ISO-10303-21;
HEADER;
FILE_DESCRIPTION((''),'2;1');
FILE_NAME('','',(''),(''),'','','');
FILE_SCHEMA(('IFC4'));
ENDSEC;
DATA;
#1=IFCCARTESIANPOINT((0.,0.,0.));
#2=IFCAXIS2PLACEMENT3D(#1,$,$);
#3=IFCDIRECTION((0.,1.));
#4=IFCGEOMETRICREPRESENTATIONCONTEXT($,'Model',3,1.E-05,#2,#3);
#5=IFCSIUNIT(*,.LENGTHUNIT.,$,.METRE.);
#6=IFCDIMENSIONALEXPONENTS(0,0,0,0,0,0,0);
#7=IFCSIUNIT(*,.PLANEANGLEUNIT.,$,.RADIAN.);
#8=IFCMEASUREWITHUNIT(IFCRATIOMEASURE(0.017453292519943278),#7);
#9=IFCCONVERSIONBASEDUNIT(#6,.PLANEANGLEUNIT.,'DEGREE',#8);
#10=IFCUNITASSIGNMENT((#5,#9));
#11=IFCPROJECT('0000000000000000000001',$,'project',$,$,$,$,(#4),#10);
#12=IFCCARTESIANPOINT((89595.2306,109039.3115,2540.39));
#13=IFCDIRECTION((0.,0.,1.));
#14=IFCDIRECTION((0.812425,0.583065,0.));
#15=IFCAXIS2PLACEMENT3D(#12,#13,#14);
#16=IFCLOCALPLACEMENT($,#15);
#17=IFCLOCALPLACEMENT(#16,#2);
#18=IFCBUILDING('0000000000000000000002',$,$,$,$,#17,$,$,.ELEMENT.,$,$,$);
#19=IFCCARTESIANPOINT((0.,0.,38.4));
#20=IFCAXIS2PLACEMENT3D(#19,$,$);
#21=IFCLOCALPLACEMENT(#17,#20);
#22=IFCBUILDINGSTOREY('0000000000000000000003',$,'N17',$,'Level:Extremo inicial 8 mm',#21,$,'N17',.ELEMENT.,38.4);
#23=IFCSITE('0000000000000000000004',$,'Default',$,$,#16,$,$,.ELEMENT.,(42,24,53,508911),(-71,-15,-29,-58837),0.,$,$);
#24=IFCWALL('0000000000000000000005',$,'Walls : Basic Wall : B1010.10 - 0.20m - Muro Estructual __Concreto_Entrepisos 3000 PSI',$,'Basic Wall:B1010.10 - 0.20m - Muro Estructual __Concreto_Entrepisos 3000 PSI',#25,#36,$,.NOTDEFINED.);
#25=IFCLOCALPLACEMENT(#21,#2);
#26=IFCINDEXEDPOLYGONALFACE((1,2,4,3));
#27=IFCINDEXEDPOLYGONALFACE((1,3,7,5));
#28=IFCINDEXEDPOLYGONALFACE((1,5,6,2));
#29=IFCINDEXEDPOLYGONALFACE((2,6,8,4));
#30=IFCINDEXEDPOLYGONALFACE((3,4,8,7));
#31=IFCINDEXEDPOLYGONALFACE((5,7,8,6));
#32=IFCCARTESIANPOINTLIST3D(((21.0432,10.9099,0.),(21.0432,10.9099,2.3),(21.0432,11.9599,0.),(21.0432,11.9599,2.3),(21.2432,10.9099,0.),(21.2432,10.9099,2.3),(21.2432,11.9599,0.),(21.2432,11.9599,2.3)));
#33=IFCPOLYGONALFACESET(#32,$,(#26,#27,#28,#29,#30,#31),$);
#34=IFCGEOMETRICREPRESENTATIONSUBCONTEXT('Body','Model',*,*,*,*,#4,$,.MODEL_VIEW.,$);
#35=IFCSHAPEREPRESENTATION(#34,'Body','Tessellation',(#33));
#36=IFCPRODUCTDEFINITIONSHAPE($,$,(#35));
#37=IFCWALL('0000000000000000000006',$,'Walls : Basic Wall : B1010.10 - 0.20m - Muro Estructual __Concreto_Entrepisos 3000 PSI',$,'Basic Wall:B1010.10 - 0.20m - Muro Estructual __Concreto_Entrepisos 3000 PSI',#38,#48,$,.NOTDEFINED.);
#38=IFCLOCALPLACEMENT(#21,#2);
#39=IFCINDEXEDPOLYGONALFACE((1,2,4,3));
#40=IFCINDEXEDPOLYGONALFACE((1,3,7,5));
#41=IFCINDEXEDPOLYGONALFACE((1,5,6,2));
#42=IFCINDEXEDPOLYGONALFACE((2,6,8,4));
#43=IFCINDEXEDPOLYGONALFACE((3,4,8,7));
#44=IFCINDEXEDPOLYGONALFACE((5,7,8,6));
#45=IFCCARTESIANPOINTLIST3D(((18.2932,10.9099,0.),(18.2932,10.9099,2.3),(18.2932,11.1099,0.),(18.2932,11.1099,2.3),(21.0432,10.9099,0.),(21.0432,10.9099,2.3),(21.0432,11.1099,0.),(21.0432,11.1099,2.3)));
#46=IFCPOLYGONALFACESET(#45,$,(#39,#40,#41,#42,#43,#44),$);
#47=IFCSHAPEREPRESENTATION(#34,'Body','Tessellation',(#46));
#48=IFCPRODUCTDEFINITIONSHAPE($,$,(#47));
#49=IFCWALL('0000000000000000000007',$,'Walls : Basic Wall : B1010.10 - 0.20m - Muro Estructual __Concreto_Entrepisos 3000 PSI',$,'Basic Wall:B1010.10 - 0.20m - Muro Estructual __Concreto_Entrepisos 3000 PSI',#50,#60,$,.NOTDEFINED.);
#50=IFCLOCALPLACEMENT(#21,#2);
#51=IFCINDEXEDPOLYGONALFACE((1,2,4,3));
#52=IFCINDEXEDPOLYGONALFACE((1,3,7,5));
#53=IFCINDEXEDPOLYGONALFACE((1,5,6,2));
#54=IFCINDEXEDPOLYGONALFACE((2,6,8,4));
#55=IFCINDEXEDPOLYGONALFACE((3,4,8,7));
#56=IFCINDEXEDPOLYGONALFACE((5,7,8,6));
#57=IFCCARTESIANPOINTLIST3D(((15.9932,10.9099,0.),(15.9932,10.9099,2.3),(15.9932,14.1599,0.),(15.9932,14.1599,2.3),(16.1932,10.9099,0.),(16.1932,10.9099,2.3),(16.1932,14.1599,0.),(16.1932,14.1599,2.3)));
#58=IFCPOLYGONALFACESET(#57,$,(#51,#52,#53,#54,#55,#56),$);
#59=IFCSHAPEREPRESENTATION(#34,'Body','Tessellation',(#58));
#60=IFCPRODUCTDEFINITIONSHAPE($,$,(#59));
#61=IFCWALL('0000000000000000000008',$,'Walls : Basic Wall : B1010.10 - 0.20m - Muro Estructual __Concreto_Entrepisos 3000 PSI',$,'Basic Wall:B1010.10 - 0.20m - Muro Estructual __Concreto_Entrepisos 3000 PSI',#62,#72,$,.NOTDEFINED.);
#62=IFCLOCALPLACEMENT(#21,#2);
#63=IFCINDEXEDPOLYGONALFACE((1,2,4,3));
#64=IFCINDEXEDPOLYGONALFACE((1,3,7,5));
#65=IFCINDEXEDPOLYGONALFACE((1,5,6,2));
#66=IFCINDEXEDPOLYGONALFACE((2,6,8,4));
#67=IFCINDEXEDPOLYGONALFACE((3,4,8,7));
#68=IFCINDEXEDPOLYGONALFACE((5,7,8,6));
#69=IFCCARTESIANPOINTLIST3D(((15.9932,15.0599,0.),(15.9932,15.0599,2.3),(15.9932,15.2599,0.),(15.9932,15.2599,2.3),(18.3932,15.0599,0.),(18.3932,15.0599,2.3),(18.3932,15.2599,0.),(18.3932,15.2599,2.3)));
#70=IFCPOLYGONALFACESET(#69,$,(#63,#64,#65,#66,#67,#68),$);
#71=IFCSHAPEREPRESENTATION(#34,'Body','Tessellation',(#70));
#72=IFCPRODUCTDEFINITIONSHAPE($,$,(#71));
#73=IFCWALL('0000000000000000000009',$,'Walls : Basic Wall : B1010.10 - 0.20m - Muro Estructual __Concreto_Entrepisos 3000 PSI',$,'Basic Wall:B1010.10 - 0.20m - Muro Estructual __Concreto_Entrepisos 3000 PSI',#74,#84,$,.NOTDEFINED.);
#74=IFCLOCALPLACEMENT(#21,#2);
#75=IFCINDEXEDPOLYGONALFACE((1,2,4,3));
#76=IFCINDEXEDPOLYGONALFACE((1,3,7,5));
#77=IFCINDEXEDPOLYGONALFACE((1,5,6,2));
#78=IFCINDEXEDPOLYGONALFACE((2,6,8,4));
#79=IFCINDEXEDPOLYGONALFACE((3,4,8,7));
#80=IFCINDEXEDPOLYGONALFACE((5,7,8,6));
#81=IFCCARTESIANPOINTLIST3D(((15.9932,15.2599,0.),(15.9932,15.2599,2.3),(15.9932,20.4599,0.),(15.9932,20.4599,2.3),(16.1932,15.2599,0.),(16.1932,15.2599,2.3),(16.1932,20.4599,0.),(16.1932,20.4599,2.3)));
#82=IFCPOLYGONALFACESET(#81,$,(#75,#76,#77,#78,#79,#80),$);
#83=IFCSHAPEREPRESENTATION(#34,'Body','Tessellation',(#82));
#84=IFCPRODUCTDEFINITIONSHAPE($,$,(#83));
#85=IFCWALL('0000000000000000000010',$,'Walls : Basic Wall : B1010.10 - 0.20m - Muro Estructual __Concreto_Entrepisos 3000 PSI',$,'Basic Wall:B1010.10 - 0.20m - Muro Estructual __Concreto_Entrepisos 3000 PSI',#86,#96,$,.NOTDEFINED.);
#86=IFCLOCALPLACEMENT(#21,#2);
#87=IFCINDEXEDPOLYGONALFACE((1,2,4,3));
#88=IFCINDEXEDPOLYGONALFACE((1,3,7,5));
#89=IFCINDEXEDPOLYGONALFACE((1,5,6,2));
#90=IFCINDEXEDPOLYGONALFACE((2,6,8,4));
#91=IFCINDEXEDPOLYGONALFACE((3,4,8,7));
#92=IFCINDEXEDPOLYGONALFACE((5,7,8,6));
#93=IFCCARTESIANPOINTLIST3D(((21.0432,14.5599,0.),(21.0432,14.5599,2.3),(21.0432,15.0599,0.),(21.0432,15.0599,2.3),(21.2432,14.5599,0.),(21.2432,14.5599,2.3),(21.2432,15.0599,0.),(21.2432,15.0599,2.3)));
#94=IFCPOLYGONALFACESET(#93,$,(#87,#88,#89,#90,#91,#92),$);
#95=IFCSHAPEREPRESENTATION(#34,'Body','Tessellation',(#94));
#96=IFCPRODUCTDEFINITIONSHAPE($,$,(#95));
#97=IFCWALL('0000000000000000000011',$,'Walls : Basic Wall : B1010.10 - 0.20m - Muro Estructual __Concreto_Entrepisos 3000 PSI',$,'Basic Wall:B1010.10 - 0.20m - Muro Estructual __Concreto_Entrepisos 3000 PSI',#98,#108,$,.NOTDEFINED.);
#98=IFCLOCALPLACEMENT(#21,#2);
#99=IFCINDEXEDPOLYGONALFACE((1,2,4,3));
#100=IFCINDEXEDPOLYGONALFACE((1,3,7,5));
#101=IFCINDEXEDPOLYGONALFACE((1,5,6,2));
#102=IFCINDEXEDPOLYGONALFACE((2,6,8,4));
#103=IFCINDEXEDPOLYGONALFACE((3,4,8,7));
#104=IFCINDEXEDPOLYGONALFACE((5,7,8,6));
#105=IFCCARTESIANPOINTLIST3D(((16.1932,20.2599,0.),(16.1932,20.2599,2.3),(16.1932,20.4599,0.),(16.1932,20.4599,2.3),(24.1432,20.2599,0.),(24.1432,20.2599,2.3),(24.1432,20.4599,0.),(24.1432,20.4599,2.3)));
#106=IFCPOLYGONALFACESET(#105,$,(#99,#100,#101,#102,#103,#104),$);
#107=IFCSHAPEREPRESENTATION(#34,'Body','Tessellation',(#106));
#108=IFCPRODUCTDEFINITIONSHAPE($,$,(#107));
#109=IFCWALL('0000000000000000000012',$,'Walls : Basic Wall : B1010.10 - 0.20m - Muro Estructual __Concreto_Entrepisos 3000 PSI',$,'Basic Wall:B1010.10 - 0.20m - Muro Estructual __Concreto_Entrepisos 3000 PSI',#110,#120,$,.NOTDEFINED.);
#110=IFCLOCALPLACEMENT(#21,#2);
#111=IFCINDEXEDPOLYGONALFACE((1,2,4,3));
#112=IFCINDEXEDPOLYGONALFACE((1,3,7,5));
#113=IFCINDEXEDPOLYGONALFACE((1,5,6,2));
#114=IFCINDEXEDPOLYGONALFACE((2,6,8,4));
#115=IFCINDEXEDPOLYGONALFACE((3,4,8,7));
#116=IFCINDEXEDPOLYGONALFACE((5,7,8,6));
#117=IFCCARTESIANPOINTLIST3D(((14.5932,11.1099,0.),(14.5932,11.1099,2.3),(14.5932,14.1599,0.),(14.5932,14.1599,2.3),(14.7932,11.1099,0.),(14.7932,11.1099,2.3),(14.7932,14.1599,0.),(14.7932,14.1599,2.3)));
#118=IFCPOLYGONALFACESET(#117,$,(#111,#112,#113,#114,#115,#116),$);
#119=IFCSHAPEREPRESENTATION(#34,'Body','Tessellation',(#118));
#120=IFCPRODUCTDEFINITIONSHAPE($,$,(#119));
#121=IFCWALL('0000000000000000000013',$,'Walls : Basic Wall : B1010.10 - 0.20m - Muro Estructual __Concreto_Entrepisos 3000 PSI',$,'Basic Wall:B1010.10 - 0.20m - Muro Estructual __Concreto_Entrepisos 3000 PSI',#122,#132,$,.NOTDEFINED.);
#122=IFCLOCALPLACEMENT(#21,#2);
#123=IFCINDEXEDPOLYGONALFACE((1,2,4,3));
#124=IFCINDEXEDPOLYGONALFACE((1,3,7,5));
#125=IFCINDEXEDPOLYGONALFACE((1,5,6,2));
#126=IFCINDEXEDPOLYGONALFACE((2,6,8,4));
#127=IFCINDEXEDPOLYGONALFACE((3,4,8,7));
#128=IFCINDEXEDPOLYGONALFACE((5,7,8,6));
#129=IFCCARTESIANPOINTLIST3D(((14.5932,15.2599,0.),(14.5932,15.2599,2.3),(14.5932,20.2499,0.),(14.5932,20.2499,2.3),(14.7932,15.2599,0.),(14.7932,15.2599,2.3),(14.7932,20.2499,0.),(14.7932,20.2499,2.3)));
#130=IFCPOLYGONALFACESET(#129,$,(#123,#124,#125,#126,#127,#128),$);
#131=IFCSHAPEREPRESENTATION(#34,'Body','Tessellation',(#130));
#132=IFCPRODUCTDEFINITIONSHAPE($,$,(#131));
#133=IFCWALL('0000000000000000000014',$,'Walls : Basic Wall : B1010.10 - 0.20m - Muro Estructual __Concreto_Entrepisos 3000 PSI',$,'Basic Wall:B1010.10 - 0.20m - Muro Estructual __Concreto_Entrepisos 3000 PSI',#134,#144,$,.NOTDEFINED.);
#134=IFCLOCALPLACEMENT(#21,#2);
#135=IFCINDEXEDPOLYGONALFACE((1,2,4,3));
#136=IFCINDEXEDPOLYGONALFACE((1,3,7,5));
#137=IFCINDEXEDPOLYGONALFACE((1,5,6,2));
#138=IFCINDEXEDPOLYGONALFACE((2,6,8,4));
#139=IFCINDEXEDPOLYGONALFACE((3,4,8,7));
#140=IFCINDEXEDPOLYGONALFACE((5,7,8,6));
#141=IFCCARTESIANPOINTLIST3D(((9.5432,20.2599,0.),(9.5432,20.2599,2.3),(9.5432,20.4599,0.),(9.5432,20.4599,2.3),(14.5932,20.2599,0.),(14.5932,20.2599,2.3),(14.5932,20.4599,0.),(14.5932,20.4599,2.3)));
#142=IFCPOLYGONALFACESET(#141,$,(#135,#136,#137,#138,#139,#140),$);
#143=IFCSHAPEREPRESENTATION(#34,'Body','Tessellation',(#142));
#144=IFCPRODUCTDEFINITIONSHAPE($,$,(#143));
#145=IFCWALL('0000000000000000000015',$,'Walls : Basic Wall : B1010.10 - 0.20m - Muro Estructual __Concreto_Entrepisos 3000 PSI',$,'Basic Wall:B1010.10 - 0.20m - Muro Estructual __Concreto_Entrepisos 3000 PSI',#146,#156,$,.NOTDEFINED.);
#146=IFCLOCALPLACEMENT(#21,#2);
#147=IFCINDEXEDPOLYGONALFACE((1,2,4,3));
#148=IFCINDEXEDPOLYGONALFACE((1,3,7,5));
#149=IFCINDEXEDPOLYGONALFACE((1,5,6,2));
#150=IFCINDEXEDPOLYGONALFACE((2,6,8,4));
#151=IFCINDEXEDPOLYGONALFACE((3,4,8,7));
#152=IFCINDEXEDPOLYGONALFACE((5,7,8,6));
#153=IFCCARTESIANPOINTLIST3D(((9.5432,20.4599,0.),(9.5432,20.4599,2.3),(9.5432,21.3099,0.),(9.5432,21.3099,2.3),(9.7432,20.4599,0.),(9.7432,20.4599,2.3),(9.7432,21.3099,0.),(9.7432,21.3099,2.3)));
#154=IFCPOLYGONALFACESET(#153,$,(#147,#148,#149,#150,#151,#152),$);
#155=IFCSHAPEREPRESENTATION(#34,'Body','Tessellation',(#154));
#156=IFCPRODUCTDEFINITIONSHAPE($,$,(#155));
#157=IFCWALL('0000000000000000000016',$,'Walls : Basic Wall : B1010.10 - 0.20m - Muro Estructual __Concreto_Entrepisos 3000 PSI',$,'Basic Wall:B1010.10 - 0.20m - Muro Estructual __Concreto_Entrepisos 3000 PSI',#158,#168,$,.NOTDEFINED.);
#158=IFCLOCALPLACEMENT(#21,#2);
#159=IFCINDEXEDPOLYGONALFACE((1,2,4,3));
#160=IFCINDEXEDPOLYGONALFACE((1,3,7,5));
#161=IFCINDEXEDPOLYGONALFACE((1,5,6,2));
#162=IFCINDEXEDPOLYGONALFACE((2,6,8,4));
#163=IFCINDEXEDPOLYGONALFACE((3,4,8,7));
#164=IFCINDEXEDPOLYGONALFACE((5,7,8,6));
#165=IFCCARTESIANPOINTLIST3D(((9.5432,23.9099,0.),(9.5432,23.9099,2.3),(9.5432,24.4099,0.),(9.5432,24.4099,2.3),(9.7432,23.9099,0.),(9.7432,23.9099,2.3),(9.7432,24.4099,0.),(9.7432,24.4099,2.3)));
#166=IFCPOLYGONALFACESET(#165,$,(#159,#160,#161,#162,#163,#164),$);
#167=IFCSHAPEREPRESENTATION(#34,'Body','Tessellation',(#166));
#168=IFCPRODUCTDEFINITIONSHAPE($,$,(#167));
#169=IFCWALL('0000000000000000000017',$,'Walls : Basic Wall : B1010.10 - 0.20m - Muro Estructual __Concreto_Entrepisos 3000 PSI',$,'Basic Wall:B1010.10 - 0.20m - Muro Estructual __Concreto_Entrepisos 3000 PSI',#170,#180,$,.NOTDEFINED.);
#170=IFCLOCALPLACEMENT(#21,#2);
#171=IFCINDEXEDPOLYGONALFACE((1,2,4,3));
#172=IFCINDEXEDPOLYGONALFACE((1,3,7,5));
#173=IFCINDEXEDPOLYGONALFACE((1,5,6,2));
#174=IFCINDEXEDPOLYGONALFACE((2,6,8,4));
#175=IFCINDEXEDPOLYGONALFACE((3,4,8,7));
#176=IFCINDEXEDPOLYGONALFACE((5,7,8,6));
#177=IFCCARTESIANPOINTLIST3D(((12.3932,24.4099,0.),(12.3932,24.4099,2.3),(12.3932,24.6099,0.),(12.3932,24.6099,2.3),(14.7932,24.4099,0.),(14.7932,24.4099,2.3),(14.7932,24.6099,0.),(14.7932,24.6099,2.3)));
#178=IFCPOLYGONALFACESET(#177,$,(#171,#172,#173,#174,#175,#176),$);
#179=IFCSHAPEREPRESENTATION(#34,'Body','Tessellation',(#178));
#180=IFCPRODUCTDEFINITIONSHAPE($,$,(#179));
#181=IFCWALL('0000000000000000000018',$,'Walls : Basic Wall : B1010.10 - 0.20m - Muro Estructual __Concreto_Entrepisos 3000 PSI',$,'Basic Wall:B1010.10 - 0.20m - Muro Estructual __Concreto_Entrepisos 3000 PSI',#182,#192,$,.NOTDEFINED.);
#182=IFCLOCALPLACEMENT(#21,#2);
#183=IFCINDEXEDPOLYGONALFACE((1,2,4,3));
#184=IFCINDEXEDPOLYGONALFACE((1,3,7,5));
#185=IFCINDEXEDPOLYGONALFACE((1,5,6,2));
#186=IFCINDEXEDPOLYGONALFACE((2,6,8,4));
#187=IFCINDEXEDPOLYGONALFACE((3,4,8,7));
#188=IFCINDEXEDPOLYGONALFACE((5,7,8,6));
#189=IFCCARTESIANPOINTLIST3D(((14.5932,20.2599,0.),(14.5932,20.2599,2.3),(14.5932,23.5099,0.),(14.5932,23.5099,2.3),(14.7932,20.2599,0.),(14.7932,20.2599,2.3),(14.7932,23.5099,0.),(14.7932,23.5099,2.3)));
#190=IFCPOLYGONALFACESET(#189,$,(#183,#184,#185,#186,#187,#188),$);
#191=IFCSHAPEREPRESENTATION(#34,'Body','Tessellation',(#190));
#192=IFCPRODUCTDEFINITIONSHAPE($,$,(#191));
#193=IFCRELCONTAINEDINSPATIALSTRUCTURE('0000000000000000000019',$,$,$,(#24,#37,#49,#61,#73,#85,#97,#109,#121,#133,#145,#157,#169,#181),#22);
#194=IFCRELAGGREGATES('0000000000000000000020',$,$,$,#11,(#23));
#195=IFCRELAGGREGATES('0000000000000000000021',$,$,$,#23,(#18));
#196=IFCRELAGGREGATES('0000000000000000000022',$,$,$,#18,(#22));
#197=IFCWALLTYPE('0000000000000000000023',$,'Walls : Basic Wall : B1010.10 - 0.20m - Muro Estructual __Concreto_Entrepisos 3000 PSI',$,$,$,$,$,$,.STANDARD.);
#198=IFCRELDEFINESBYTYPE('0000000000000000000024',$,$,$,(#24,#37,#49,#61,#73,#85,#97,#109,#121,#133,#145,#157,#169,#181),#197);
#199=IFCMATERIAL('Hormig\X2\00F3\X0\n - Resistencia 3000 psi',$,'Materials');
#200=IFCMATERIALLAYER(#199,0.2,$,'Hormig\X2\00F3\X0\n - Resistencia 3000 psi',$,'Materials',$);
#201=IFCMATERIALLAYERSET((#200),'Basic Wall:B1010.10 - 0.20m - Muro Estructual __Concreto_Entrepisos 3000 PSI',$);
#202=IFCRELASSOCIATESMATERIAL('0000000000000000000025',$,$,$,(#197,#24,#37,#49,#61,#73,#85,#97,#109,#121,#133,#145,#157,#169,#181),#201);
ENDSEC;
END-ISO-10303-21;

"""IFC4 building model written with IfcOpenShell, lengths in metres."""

from ifc_helpers import new_model, entity, si_unit, converted_unit, direction, frame, frame_2d, origin, place, context, subcontext, project, spatial, rectangle, extrude, material, layer, layer_set, layer_usage, type_object, element, save


model = new_model("IFC4")

# Units and contexts
model_context = context("Model", 3, precision=1e-05, world=origin(), true_north=direction((0.0, 1.0)))
body_context = subcontext(model_context, "Body", "Model", "MODEL_VIEW")
ifc_project = project(units=[si_unit("LENGTHUNIT", "METRE"), converted_unit("PLANEANGLEUNIT", "DEGREE", entity("IfcRatioMeasure", 0.017453292519943278), si_unit("PLANEANGLEUNIT", "RADIAN"), dimensions=[0, 0, 0, 0, 0, 0, 0])], contexts=[model_context])

# Site, building, storey
site_placement = place(None, frame((89595.2306, 109039.3115, 2540.39), z_axis=(0.0, 0.0, 1.0), x_axis=(0.812425, 0.583065, 0.0)))
site = spatial("IfcSite", under=ifc_project, at=site_placement, Name="Default", CompositionType="ELEMENT", RefLatitude=(42, 24, 53, 508911), RefLongitude=(-71, -15, -29, -58837), RefElevation=0.0)
building_placement = place(site_placement, origin())
building = spatial("IfcBuilding", under=site, at=building_placement, CompositionType="ELEMENT")
storey_placement = place(building_placement, frame((0.0, 0.0, 38.4)))
storey = spatial("IfcBuildingStorey", under=building, at=storey_placement, Name="N17", ObjectType="Level:Extremo inicial 8 mm", LongName="N17", CompositionType="ELEMENT", Elevation=38.4)

# Walls
ifc_material = material(Name="Hormigón - Resistencia 3000 psi", Category="Materials")
ifc_layer_1 = layer(ifc_material, 0.2, Name="Hormigón - Resistencia 3000 psi", Category="Materials")
ifc_layer_set_1 = layer_set([ifc_layer_1], Name="Basic Wall:B1010.10 - 0.20m - Muro Estructual __Concreto_Entrepisos 3000 PSI")
ifc_layer_usage_1 = layer_usage(ifc_layer_set_1, "AXIS2", "NEGATIVE", 0.1)
wall_type_1 = type_object("IfcWallType", Name="Walls : Basic Wall : B1010.10 - 0.20m - Muro Estructual __Concreto_Entrepisos 3000 PSI", PredefinedType="STANDARD", material=ifc_layer_set_1)
wall_1_placement = place(storey_placement, frame((21.1432, 11.9599, 0.0), z_axis=(0.0, 0.0, 1.0), x_axis=(0.0, -1.0, 0.0)))
element("IfcWall", 1, at=wall_1_placement, inside=storey, type_object=wall_type_1, material=ifc_layer_usage_1, Name="Walls : Basic Wall : B1010.10 - 0.20m - Muro Estructual __Concreto_Entrepisos 3000 PSI", ObjectType="Basic Wall:B1010.10 - 0.20m - Muro Estructual __Concreto_Entrepisos 3000 PSI", PredefinedType="NOTDEFINED", context=body_context, shape_type="SweptSolid", body=[
    extrude(rectangle(XDim=1.05, YDim=0.2, at=frame_2d((0.525, 0.0), x_axis=(-1.0, 0.0))), origin(), (0.0, 0.0, 1.0), 2.3),
])
ifc_layer_usage_2 = layer_usage(ifc_layer_set_1, "AXIS2", "NEGATIVE", 0.1)
wall_2_placement = place(storey_placement, frame((21.0432, 11.0099, 0.0), z_axis=(0.0, 0.0, 1.0), x_axis=(-1.0, 0.0, 0.0)))
element("IfcWall", 2, at=wall_2_placement, inside=storey, type_object=wall_type_1, material=ifc_layer_usage_2, Name="Walls : Basic Wall : B1010.10 - 0.20m - Muro Estructual __Concreto_Entrepisos 3000 PSI", ObjectType="Basic Wall:B1010.10 - 0.20m - Muro Estructual __Concreto_Entrepisos 3000 PSI", PredefinedType="NOTDEFINED", context=body_context, shape_type="SweptSolid", body=[
    extrude(rectangle(XDim=2.75, YDim=0.2, at=frame_2d((1.375, 0.0), x_axis=(-1.0, 0.0))), origin(), (0.0, 0.0, 1.0), 2.3),
])
ifc_layer_usage_3 = layer_usage(ifc_layer_set_1, "AXIS2", "NEGATIVE", 0.1)
wall_3_placement = place(storey_placement, frame((16.0932, 14.1599, 0.0), z_axis=(0.0, 0.0, 1.0), x_axis=(0.0, -1.0, 0.0)))
element("IfcWall", 3, at=wall_3_placement, inside=storey, type_object=wall_type_1, material=ifc_layer_usage_3, Name="Walls : Basic Wall : B1010.10 - 0.20m - Muro Estructual __Concreto_Entrepisos 3000 PSI", ObjectType="Basic Wall:B1010.10 - 0.20m - Muro Estructual __Concreto_Entrepisos 3000 PSI", PredefinedType="NOTDEFINED", context=body_context, shape_type="SweptSolid", body=[
    extrude(rectangle(XDim=3.25, YDim=0.2, at=frame_2d((1.625, 0.0), x_axis=(-1.0, 0.0))), origin(), (0.0, 0.0, 1.0), 2.3),
])
ifc_layer_usage_4 = layer_usage(ifc_layer_set_1, "AXIS2", "NEGATIVE", 0.1)
wall_4_placement = place(storey_placement, frame((18.3932, 15.1599, 0.0), z_axis=(0.0, 0.0, 1.0), x_axis=(-1.0, 0.0, 0.0)))
element("IfcWall", 4, at=wall_4_placement, inside=storey, type_object=wall_type_1, material=ifc_layer_usage_4, Name="Walls : Basic Wall : B1010.10 - 0.20m - Muro Estructual __Concreto_Entrepisos 3000 PSI", ObjectType="Basic Wall:B1010.10 - 0.20m - Muro Estructual __Concreto_Entrepisos 3000 PSI", PredefinedType="NOTDEFINED", context=body_context, shape_type="SweptSolid", body=[
    extrude(rectangle(XDim=2.4, YDim=0.2, at=frame_2d((1.2, 0.0), x_axis=(-1.0, 0.0))), origin(), (0.0, 0.0, 1.0), 2.3),
])
ifc_layer_usage_5 = layer_usage(ifc_layer_set_1, "AXIS2", "NEGATIVE", 0.1)
wall_5_placement = place(storey_placement, frame((16.0932, 15.2599, 0.0), z_axis=(0.0, 0.0, 1.0), x_axis=(0.0, 1.0, 0.0)))
element("IfcWall", 5, at=wall_5_placement, inside=storey, type_object=wall_type_1, material=ifc_layer_usage_5, Name="Walls : Basic Wall : B1010.10 - 0.20m - Muro Estructual __Concreto_Entrepisos 3000 PSI", ObjectType="Basic Wall:B1010.10 - 0.20m - Muro Estructual __Concreto_Entrepisos 3000 PSI", PredefinedType="NOTDEFINED", context=body_context, shape_type="SweptSolid", body=[
    extrude(rectangle(XDim=5.2, YDim=0.2, at=frame_2d((2.6, 0.0), x_axis=(-1.0, 0.0))), origin(), (0.0, 0.0, 1.0), 2.3),
])
ifc_layer_usage_6 = layer_usage(ifc_layer_set_1, "AXIS2", "NEGATIVE", 0.1)
wall_6_placement = place(storey_placement, frame((21.1432, 14.5599, 0.0), z_axis=(0.0, 0.0, 1.0), x_axis=(0.0, 1.0, 0.0)))
element("IfcWall", 6, at=wall_6_placement, inside=storey, type_object=wall_type_1, material=ifc_layer_usage_6, Name="Walls : Basic Wall : B1010.10 - 0.20m - Muro Estructual __Concreto_Entrepisos 3000 PSI", ObjectType="Basic Wall:B1010.10 - 0.20m - Muro Estructual __Concreto_Entrepisos 3000 PSI", PredefinedType="NOTDEFINED", context=body_context, shape_type="SweptSolid", body=[
    extrude(rectangle(XDim=0.5, YDim=0.2, at=frame_2d((0.25, 0.0), x_axis=(-1.0, 0.0))), origin(), (0.0, 0.0, 1.0), 2.3),
])
ifc_layer_usage_7 = layer_usage(ifc_layer_set_1, "AXIS2", "NEGATIVE", 0.1)
wall_7_placement = place(storey_placement, frame((16.1932, 20.3599, 0.0)))
element("IfcWall", 7, at=wall_7_placement, inside=storey, type_object=wall_type_1, material=ifc_layer_usage_7, Name="Walls : Basic Wall : B1010.10 - 0.20m - Muro Estructual __Concreto_Entrepisos 3000 PSI", ObjectType="Basic Wall:B1010.10 - 0.20m - Muro Estructual __Concreto_Entrepisos 3000 PSI", PredefinedType="NOTDEFINED", context=body_context, shape_type="SweptSolid", body=[
    extrude(rectangle(XDim=7.95, YDim=0.2, at=frame_2d((3.975, 0.0), x_axis=(-1.0, 0.0))), origin(), (0.0, 0.0, 1.0), 2.3),
])
ifc_layer_usage_8 = layer_usage(ifc_layer_set_1, "AXIS2", "POSITIVE", -0.1)
wall_8_placement = place(storey_placement, frame((14.6932, 14.1599, 0.0), z_axis=(0.0, 0.0, 1.0), x_axis=(0.0, -1.0, 0.0)))
element("IfcWall", 8, at=wall_8_placement, inside=storey, type_object=wall_type_1, material=ifc_layer_usage_8, Name="Walls : Basic Wall : B1010.10 - 0.20m - Muro Estructual __Concreto_Entrepisos 3000 PSI", ObjectType="Basic Wall:B1010.10 - 0.20m - Muro Estructual __Concreto_Entrepisos 3000 PSI", PredefinedType="NOTDEFINED", context=body_context, shape_type="SweptSolid", body=[
    extrude(rectangle(XDim=3.05, YDim=0.2, at=frame_2d((1.525, 0.0), x_axis=(-1.0, 0.0))), origin(), (0.0, 0.0, 1.0), 2.3),
])
ifc_layer_usage_9 = layer_usage(ifc_layer_set_1, "AXIS2", "POSITIVE", -0.1)
wall_9_placement = place(storey_placement, frame((14.6932, 15.2599, 0.0), z_axis=(0.0, 0.0, 1.0), x_axis=(0.0, 1.0, 0.0)))
element("IfcWall", 9, at=wall_9_placement, inside=storey, type_object=wall_type_1, material=ifc_layer_usage_9, Name="Walls : Basic Wall : B1010.10 - 0.20m - Muro Estructual __Concreto_Entrepisos 3000 PSI", ObjectType="Basic Wall:B1010.10 - 0.20m - Muro Estructual __Concreto_Entrepisos 3000 PSI", PredefinedType="NOTDEFINED", context=body_context, shape_type="SweptSolid", body=[
    extrude(rectangle(XDim=4.99, YDim=0.2, at=frame_2d((2.495, 0.0), x_axis=(-1.0, 0.0))), origin(), (0.0, 0.0, 1.0), 2.3),
])
ifc_layer_usage_10 = layer_usage(ifc_layer_set_1, "AXIS2", "POSITIVE", -0.1)
wall_10_placement = place(storey_placement, frame((14.5932, 20.3599, 0.0), z_axis=(0.0, 0.0, 1.0), x_axis=(-1.0, 0.0, 0.0)))
element("IfcWall", 10, at=wall_10_placement, inside=storey, type_object=wall_type_1, material=ifc_layer_usage_10, Name="Walls : Basic Wall : B1010.10 - 0.20m - Muro Estructual __Concreto_Entrepisos 3000 PSI", ObjectType="Basic Wall:B1010.10 - 0.20m - Muro Estructual __Concreto_Entrepisos 3000 PSI", PredefinedType="NOTDEFINED", context=body_context, shape_type="SweptSolid", body=[
    extrude(rectangle(XDim=5.05, YDim=0.2, at=frame_2d((2.525, 0.0), x_axis=(-1.0, 0.0))), origin(), (0.0, 0.0, 1.0), 2.3),
])
ifc_layer_usage_11 = layer_usage(ifc_layer_set_1, "AXIS2", "NEGATIVE", 0.1)
wall_11_placement = place(storey_placement, frame((9.6432, 20.4599, 0.0), z_axis=(0.0, 0.0, 1.0), x_axis=(0.0, 1.0, 0.0)))
element("IfcWall", 11, at=wall_11_placement, inside=storey, type_object=wall_type_1, material=ifc_layer_usage_11, Name="Walls : Basic Wall : B1010.10 - 0.20m - Muro Estructual __Concreto_Entrepisos 3000 PSI", ObjectType="Basic Wall:B1010.10 - 0.20m - Muro Estructual __Concreto_Entrepisos 3000 PSI", PredefinedType="NOTDEFINED", context=body_context, shape_type="SweptSolid", body=[
    extrude(rectangle(XDim=0.85, YDim=0.2, at=frame_2d((0.425, 0.0), x_axis=(-1.0, 0.0))), origin(), (0.0, 0.0, 1.0), 2.3),
])
ifc_layer_usage_12 = layer_usage(ifc_layer_set_1, "AXIS2", "NEGATIVE", 0.1)
wall_12_placement = place(storey_placement, frame((9.6432, 23.9099, 0.0), z_axis=(0.0, 0.0, 1.0), x_axis=(0.0, 1.0, 0.0)))
element("IfcWall", 12, at=wall_12_placement, inside=storey, type_object=wall_type_1, material=ifc_layer_usage_12, Name="Walls : Basic Wall : B1010.10 - 0.20m - Muro Estructual __Concreto_Entrepisos 3000 PSI", ObjectType="Basic Wall:B1010.10 - 0.20m - Muro Estructual __Concreto_Entrepisos 3000 PSI", PredefinedType="NOTDEFINED", context=body_context, shape_type="SweptSolid", body=[
    extrude(rectangle(XDim=0.5, YDim=0.2, at=frame_2d((0.25, 0.0), x_axis=(-1.0, 0.0))), origin(), (0.0, 0.0, 1.0), 2.3),
])
ifc_layer_usage_13 = layer_usage(ifc_layer_set_1, "AXIS2", "NEGATIVE", 0.1)
wall_13_placement = place(storey_placement, frame((12.3932, 24.5099, 0.0)))
element("IfcWall", 13, at=wall_13_placement, inside=storey, type_object=wall_type_1, material=ifc_layer_usage_13, Name="Walls : Basic Wall : B1010.10 - 0.20m - Muro Estructual __Concreto_Entrepisos 3000 PSI", ObjectType="Basic Wall:B1010.10 - 0.20m - Muro Estructual __Concreto_Entrepisos 3000 PSI", PredefinedType="NOTDEFINED", context=body_context, shape_type="SweptSolid", body=[
    extrude(rectangle(XDim=2.4, YDim=0.2, at=frame_2d((1.2, 0.0), x_axis=(-1.0, 0.0))), origin(), (0.0, 0.0, 1.0), 2.3),
])
ifc_layer_usage_14 = layer_usage(ifc_layer_set_1, "AXIS2", "POSITIVE", -0.1)
wall_14_placement = place(storey_placement, frame((14.6932, 20.2599, 0.0), z_axis=(0.0, 0.0, 1.0), x_axis=(0.0, 1.0, 0.0)))
element("IfcWall", 14, at=wall_14_placement, inside=storey, type_object=wall_type_1, material=ifc_layer_usage_14, Name="Walls : Basic Wall : B1010.10 - 0.20m - Muro Estructual __Concreto_Entrepisos 3000 PSI", ObjectType="Basic Wall:B1010.10 - 0.20m - Muro Estructual __Concreto_Entrepisos 3000 PSI", PredefinedType="NOTDEFINED", context=body_context, shape_type="SweptSolid", body=[
    extrude(rectangle(XDim=3.25, YDim=0.2, at=frame_2d((1.625, 0.0), x_axis=(-1.0, 0.0))), origin(), (0.0, 0.0, 1.0), 2.3),
])

save(model, "model.ifc")
